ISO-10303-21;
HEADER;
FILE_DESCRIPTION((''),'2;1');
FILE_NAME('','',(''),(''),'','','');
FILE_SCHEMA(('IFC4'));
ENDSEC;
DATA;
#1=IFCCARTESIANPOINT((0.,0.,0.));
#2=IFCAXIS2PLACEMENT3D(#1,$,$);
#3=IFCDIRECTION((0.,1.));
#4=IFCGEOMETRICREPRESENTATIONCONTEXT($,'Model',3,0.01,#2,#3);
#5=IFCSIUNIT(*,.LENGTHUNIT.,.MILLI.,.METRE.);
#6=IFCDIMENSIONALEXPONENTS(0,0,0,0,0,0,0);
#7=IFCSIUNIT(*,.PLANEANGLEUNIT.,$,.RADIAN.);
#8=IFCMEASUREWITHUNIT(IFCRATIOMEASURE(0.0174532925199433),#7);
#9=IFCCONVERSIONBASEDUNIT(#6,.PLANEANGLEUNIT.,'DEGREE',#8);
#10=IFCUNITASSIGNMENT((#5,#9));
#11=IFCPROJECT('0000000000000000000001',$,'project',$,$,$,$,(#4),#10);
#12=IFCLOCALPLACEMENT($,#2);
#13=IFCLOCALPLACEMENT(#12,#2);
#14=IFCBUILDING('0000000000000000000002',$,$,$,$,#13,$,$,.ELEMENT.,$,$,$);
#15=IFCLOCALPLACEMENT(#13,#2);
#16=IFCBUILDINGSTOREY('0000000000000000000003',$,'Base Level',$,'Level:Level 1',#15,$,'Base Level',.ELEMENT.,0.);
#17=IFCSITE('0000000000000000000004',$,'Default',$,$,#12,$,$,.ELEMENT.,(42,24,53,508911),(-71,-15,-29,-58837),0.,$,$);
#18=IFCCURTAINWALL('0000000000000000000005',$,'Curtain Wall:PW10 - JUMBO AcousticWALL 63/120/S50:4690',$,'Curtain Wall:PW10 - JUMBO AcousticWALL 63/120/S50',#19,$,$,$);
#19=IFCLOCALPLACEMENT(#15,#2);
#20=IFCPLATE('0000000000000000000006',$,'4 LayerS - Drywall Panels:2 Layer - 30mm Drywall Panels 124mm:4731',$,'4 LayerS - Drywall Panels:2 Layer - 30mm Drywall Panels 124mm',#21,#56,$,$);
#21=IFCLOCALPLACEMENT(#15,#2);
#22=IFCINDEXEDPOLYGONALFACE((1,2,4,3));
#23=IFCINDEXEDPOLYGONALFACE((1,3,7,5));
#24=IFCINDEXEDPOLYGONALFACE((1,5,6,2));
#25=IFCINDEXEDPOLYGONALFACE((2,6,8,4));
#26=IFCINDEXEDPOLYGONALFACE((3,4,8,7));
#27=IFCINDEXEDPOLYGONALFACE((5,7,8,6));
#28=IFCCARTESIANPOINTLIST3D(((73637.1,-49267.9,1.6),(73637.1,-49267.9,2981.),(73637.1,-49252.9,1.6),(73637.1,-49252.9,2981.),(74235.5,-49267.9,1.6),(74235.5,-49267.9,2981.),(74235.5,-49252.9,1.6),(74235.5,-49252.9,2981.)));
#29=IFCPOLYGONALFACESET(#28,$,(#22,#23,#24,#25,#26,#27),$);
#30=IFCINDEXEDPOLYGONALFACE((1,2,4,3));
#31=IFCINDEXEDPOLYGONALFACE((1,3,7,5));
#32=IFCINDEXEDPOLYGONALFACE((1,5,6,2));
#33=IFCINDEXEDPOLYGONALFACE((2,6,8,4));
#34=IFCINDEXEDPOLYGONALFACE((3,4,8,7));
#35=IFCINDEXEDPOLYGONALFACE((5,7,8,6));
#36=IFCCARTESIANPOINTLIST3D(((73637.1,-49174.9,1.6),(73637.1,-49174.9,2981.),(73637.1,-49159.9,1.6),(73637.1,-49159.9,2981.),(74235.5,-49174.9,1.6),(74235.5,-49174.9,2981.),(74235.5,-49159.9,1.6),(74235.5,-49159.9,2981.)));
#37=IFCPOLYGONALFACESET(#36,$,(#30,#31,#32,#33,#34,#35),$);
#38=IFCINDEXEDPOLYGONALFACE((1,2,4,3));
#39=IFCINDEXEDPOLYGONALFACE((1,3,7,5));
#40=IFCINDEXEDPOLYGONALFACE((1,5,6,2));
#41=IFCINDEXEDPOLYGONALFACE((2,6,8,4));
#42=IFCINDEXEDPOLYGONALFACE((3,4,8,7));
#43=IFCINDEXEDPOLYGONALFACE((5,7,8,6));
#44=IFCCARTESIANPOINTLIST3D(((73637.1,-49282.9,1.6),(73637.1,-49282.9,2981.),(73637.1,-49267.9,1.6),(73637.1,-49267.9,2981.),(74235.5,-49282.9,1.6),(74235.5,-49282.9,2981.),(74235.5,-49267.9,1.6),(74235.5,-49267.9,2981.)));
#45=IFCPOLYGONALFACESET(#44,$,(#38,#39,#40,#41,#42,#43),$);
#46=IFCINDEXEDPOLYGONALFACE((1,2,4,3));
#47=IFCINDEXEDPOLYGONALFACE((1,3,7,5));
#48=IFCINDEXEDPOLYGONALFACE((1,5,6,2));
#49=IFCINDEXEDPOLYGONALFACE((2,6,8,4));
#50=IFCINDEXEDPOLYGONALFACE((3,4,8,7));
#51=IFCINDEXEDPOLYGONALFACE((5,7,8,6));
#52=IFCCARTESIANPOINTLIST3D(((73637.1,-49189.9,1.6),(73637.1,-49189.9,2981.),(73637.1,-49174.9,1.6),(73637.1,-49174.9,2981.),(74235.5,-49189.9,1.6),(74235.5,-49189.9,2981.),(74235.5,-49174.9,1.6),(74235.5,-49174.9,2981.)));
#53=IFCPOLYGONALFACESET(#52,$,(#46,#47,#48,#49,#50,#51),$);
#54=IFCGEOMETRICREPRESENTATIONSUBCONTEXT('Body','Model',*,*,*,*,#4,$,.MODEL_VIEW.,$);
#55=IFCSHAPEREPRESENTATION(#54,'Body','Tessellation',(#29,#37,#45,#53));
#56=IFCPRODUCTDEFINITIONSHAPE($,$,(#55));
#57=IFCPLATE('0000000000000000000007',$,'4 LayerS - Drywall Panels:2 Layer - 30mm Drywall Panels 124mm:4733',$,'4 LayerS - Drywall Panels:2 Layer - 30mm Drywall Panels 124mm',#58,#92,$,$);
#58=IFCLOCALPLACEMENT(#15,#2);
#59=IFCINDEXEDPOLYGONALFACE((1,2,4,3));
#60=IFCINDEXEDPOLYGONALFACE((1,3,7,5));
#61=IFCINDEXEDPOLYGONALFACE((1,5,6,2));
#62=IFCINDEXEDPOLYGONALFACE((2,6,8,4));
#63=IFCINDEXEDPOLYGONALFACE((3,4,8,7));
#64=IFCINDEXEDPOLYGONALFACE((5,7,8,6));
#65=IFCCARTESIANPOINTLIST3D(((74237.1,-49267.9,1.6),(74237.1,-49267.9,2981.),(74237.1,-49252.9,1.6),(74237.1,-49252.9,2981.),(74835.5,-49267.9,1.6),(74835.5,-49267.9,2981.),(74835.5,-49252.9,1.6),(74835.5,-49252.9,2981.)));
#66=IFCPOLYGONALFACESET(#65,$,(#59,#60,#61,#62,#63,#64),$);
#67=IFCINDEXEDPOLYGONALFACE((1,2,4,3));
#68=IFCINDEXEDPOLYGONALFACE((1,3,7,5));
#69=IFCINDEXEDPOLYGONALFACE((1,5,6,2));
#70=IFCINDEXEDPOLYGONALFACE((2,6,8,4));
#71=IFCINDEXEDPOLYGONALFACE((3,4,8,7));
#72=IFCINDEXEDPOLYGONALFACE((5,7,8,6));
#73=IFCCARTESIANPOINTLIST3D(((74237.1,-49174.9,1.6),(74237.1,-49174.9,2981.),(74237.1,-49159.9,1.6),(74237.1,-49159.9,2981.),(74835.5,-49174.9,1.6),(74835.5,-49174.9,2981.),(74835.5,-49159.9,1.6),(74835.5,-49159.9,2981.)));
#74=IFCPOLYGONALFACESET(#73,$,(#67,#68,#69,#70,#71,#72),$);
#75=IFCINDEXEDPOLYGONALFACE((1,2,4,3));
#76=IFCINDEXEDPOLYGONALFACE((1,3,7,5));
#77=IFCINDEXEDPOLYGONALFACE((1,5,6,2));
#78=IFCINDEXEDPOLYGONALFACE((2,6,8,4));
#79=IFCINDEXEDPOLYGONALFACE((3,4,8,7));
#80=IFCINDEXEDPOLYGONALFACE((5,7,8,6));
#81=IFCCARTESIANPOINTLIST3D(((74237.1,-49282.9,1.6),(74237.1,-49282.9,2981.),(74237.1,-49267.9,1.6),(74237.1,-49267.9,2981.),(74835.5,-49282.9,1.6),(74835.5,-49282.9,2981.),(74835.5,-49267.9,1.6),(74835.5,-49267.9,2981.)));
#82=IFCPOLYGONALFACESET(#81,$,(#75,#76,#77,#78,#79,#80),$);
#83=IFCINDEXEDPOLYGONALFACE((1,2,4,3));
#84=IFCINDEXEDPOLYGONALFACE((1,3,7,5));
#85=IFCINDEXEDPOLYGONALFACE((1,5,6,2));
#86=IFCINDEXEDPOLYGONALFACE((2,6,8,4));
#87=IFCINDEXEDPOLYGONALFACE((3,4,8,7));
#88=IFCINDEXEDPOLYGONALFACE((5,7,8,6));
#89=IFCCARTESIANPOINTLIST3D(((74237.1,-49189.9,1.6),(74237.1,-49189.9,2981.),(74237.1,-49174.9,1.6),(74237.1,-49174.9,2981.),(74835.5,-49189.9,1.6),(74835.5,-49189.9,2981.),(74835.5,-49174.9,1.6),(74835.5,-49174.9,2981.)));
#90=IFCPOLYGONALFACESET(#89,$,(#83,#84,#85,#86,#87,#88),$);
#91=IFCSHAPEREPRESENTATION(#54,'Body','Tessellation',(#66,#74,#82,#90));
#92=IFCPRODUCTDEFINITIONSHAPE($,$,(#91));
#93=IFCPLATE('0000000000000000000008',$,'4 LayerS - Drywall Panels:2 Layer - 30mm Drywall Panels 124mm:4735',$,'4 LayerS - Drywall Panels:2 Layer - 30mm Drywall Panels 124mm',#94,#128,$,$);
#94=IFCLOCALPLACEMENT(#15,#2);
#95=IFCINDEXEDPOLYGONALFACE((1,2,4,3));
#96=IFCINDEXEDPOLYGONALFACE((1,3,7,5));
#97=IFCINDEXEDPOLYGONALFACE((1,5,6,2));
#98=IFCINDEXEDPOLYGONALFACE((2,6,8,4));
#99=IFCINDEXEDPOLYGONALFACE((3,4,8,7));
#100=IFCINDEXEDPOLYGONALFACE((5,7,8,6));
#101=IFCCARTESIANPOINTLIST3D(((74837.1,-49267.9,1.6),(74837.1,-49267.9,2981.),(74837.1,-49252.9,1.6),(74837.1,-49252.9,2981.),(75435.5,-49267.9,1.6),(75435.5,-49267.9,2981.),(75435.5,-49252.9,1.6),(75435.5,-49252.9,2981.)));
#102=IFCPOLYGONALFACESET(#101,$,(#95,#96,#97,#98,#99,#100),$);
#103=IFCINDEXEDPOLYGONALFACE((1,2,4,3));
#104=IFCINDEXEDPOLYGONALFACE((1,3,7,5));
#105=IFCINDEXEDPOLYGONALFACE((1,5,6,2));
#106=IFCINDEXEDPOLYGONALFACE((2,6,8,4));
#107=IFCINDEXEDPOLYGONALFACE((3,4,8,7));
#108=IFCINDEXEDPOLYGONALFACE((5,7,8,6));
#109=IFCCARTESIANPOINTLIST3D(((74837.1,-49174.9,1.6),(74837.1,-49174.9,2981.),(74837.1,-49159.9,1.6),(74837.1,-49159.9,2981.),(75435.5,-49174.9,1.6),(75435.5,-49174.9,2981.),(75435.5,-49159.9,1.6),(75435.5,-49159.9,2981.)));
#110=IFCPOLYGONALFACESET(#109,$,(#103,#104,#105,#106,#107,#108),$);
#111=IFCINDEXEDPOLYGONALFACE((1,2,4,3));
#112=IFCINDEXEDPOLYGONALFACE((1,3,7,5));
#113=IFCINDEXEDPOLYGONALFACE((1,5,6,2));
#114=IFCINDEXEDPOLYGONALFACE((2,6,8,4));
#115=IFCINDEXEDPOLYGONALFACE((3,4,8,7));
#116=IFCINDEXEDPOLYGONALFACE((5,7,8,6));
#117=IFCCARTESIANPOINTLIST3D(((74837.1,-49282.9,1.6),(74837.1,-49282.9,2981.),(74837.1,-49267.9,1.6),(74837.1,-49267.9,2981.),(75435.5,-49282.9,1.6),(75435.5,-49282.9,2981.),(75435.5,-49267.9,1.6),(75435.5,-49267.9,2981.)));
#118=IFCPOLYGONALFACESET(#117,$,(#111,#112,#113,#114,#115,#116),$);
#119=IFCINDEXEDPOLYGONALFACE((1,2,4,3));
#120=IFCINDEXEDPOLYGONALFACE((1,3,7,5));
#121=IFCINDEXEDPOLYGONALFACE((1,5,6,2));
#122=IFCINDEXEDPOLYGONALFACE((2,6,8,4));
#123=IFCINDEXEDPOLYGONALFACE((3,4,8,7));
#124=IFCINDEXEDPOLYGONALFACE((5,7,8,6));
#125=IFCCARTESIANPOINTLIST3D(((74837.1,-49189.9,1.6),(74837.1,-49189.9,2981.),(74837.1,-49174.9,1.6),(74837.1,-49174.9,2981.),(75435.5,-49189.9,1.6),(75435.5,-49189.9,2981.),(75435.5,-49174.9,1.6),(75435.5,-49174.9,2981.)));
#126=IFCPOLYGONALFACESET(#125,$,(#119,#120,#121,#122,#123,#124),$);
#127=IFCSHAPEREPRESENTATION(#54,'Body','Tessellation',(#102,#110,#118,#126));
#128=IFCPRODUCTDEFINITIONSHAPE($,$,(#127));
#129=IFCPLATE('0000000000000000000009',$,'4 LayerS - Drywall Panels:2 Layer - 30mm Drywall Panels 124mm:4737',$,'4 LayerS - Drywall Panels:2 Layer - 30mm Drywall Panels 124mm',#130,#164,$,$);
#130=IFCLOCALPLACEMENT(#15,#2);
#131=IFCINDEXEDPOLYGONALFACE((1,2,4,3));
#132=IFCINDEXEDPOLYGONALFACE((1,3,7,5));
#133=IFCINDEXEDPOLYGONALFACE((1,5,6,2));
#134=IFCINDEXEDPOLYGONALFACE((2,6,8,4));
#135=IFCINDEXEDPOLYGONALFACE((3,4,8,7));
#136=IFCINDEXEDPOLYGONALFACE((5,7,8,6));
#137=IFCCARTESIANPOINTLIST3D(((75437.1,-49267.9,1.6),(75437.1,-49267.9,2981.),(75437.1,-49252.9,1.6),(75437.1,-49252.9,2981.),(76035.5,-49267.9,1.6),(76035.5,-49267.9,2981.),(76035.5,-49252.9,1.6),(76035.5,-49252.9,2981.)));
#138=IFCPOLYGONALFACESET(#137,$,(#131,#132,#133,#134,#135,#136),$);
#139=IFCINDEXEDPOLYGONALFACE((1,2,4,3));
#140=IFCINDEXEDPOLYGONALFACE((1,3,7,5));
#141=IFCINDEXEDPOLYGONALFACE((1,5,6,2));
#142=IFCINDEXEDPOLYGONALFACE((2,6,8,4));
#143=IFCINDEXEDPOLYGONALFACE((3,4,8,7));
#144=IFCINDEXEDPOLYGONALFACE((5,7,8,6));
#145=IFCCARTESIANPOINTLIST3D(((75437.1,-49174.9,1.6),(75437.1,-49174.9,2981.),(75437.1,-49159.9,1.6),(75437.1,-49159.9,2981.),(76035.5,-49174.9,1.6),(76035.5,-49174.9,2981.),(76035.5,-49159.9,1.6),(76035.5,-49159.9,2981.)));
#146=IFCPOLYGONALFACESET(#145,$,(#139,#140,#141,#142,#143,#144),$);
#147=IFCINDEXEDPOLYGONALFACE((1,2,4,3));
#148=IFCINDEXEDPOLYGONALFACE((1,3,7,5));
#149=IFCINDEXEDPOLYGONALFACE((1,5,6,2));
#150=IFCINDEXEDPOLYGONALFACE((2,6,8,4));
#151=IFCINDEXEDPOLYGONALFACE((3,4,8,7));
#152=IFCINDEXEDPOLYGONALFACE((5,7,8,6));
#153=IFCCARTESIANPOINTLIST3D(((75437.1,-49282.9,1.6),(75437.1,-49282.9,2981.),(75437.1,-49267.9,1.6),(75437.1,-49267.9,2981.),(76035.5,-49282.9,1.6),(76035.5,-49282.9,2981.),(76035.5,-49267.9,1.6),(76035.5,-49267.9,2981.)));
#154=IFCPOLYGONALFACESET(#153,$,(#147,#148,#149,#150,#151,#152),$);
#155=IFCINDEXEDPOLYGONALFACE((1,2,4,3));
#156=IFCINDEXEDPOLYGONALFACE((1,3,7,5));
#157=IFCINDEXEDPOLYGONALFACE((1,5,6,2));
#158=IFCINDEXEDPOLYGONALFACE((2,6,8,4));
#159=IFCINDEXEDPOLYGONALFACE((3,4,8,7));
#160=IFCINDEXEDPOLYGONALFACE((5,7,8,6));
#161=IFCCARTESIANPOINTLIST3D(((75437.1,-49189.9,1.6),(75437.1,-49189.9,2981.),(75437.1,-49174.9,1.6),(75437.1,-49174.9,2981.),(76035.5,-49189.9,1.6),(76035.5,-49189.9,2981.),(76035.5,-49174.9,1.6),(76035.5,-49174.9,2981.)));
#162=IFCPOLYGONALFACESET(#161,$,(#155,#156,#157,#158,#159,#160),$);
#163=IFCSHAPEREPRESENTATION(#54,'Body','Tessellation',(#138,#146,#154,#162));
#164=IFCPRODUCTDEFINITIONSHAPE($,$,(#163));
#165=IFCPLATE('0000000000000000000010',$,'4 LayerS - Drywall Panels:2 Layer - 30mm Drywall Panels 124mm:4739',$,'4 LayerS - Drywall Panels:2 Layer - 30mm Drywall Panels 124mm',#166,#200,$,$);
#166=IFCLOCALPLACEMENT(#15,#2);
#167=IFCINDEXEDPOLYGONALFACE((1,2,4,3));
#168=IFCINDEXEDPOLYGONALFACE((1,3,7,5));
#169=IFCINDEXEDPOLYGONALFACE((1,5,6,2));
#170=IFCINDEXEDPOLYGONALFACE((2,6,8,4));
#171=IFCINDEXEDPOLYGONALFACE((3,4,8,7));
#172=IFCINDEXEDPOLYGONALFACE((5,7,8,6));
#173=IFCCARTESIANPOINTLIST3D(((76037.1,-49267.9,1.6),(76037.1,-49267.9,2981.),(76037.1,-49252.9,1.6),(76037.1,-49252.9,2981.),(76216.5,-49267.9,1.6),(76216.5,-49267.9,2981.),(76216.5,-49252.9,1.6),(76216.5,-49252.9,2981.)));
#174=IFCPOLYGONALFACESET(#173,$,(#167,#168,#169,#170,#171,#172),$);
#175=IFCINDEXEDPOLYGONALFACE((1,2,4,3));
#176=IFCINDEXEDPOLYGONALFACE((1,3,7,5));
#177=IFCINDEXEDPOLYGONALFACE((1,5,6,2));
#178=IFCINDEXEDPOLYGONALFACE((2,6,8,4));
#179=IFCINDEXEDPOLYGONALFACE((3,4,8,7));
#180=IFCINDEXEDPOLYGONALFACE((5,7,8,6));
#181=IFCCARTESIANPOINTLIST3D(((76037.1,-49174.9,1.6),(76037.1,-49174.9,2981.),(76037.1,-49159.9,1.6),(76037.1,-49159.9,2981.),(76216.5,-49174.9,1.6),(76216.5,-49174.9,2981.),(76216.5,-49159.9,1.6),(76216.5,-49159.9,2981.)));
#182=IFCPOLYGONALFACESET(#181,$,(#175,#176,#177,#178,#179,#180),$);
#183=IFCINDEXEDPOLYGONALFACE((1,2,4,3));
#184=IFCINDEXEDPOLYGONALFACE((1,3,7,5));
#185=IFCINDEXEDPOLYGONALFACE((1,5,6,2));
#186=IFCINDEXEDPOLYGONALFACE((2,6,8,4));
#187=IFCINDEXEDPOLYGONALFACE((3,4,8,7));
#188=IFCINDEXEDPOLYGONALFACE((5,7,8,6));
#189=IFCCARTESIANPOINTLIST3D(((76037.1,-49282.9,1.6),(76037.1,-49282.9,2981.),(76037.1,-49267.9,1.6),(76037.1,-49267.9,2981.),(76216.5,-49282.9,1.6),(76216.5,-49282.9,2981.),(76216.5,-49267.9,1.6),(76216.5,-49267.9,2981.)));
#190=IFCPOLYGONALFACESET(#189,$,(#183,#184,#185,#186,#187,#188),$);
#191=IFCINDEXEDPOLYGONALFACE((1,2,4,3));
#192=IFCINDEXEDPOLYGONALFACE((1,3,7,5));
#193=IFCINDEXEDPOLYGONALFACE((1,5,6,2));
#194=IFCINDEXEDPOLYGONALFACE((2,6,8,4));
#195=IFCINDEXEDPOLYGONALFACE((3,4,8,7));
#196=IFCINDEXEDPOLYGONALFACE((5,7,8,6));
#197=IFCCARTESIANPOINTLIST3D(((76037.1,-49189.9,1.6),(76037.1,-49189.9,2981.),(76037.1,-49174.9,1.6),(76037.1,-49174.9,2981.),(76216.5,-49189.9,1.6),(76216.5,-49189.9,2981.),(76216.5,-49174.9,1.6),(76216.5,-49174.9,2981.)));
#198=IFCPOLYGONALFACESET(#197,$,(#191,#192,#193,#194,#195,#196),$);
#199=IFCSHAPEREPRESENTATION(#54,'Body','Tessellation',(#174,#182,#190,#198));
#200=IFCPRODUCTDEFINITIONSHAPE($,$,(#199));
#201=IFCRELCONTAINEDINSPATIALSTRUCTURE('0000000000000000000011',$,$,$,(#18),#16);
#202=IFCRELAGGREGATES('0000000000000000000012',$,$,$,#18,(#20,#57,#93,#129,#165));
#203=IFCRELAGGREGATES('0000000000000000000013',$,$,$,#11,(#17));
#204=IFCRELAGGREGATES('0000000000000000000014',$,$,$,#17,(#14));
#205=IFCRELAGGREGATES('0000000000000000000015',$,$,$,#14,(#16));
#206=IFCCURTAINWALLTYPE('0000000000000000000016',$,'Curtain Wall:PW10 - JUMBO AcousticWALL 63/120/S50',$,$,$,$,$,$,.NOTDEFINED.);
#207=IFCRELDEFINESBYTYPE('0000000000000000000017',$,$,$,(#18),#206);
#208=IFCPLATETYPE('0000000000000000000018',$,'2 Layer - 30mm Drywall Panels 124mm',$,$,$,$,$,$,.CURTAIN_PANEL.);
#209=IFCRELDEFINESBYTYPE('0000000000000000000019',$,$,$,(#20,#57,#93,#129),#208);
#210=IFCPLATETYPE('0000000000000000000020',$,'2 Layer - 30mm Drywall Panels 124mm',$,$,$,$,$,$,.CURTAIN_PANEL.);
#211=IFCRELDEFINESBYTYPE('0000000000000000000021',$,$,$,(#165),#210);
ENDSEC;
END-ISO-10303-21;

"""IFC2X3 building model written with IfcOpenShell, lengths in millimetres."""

from ifc_helpers import new_model, entity, si_unit, converted_unit, direction, frame, frame_2d, origin, origin_2d_with_axis, place, context, subcontext, project, spatial, rectangle, extrude, source, transform, mapped, type_object, type_shapes, element, aggregate, save


model = new_model("IFC2X3")

# Units and contexts
model_context = context("Model", 3, precision=0.01, world=origin(), true_north=direction((0.0, 1.0)))
body_context = subcontext(model_context, "Body", "Model", "MODEL_VIEW")
ifc_project = project(units=[si_unit("LENGTHUNIT", "METRE", prefix="MILLI"), converted_unit("PLANEANGLEUNIT", "DEGREE", entity("IfcRatioMeasure", 0.0174532925199433), si_unit("PLANEANGLEUNIT", "RADIAN"), dimensions=[0, 0, 0, 0, 0, 0, 0])], contexts=[model_context])

# Site, building, storey
site_placement = place(None, origin())
site = spatial("IfcSite", under=ifc_project, at=site_placement, Name="Default", CompositionType="ELEMENT", RefLatitude=(42, 24, 53, 508911), RefLongitude=(-71, -15, -29, -58837), RefElevation=0.0)
building_placement = place(site_placement, origin())
building = spatial("IfcBuilding", under=site, at=building_placement, CompositionType="ELEMENT")
storey_placement = place(building_placement, origin())
storey = spatial("IfcBuildingStorey", under=building, at=storey_placement, Name="Base Level", ObjectType="Level:Level 1", LongName="Base Level", CompositionType="ELEMENT", Elevation=0.0)

# Curtain wall, plates
curtain_wall_type = type_object("IfcCurtainWallType", Name="Curtain Wall:PW10 - JUMBO AcousticWALL 63/120/S50", PredefinedType="NOTDEFINED")
curtain_wall_placement = place(building_placement, origin())
curtain_wall = element("IfcCurtainWall", 1, at=curtain_wall_placement, inside=storey, type_object=curtain_wall_type, Name="Curtain Wall:PW10 - JUMBO AcousticWALL 63/120/S50:4690", ObjectType="Curtain Wall:PW10 - JUMBO AcousticWALL 63/120/S50")
plate_type_1 = type_object("IfcPlateType", Name="2 Layer - 30mm Drywall Panels 124mm", PredefinedType="CURTAIN_PANEL")
shared_shape_1 = source(origin(), body_context, "Body", "SweptSolid", [
    extrude(rectangle(XDim=15.0, YDim=598.4, at=origin_2d_with_axis()), frame((0.0, -39.0, 0.0), z_axis=(0.0, 0.0, 1.0), x_axis=(0.0, 1.0, 0.0)), (0.0, 0.0, 1.0), 2979.4),
    extrude(rectangle(XDim=15.0, YDim=598.4, at=origin_2d_with_axis()), frame((0.0, 54.0, 0.0), z_axis=(0.0, 0.0, 1.0), x_axis=(0.0, 1.0, 0.0)), (0.0, 0.0, 1.0), 2979.4),
    extrude(rectangle(XDim=598.4, YDim=15.0, at=frame_2d((0.0, 0.0), x_axis=(1.0, 0.0))), frame((0.0, -54.0, 0.0), z_axis=(0.0, 0.0, 1.0), x_axis=(-1.0, 0.0, 0.0)), (0.0, 0.0, 1.0), 2979.4),
    extrude(rectangle(XDim=15.0, YDim=598.4, at=frame_2d((0.0, 0.0), x_axis=(1.0, 0.0))), frame((0.0, 39.0, 0.0), z_axis=(0.0, 0.0, 1.0), x_axis=(0.0, 1.0, 0.0)), (0.0, 0.0, 1.0), 2979.4),
])
type_shapes(plate_type_1, [shared_shape_1])
plate_1_placement = place(curtain_wall_placement, frame((73936.3, -49221.4, 1.6)))
plate_1 = element("IfcPlate", 2, at=plate_1_placement, type_object=plate_type_1, Name="4 LayerS - Drywall Panels:2 Layer - 30mm Drywall Panels 124mm:4731", ObjectType="4 LayerS - Drywall Panels:2 Layer - 30mm Drywall Panels 124mm", context=body_context, shape_type="MappedRepresentation", body=[
    mapped(shared_shape_1, transform((0.0, 0.0, 0.0), scale=1.0)),
])
plate_2_placement = place(curtain_wall_placement, frame((74536.3, -49221.4, 1.6)))
plate_2 = element("IfcPlate", 3, at=plate_2_placement, type_object=plate_type_1, Name="4 LayerS - Drywall Panels:2 Layer - 30mm Drywall Panels 124mm:4733", ObjectType="4 LayerS - Drywall Panels:2 Layer - 30mm Drywall Panels 124mm", context=body_context, shape_type="MappedRepresentation", body=[
    mapped(shared_shape_1, transform((0.0, 0.0, 0.0), scale=1.0)),
])
plate_3_placement = place(curtain_wall_placement, frame((75136.3, -49221.4, 1.6)))
plate_3 = element("IfcPlate", 4, at=plate_3_placement, type_object=plate_type_1, Name="4 LayerS - Drywall Panels:2 Layer - 30mm Drywall Panels 124mm:4735", ObjectType="4 LayerS - Drywall Panels:2 Layer - 30mm Drywall Panels 124mm", context=body_context, shape_type="MappedRepresentation", body=[
    mapped(shared_shape_1, transform((0.0, 0.0, 0.0), scale=1.0)),
])
plate_4_placement = place(curtain_wall_placement, frame((75736.3, -49221.4, 1.6)))
plate_4 = element("IfcPlate", 5, at=plate_4_placement, type_object=plate_type_1, Name="4 LayerS - Drywall Panels:2 Layer - 30mm Drywall Panels 124mm:4737", ObjectType="4 LayerS - Drywall Panels:2 Layer - 30mm Drywall Panels 124mm", context=body_context, shape_type="MappedRepresentation", body=[
    mapped(shared_shape_1, transform((0.0, 0.0, 0.0), scale=1.0)),
])
plate_type_2 = type_object("IfcPlateType", Name="2 Layer - 30mm Drywall Panels 124mm", PredefinedType="CURTAIN_PANEL")
shared_shape_2 = source(origin(), body_context, "Body", "SweptSolid", [
    extrude(rectangle(XDim=15.0, YDim=179.4, at=origin_2d_with_axis()), frame((0.0, -39.0, 0.0), z_axis=(0.0, 0.0, 1.0), x_axis=(0.0, 1.0, 0.0)), (0.0, 0.0, 1.0), 2979.4),
    extrude(rectangle(XDim=15.0, YDim=179.4, at=origin_2d_with_axis()), frame((0.0, 54.0, 0.0), z_axis=(0.0, 0.0, 1.0), x_axis=(0.0, 1.0, 0.0)), (0.0, 0.0, 1.0), 2979.4),
    extrude(rectangle(XDim=179.4, YDim=15.0, at=frame_2d((0.0, 0.0), x_axis=(1.0, 0.0))), frame((0.0, -54.0, 0.0), z_axis=(0.0, 0.0, 1.0), x_axis=(-1.0, 0.0, 0.0)), (0.0, 0.0, 1.0), 2979.4),
    extrude(rectangle(XDim=15.0, YDim=179.4, at=frame_2d((0.0, 0.0), x_axis=(1.0, 0.0))), frame((0.0, 39.0, 0.0), z_axis=(0.0, 0.0, 1.0), x_axis=(0.0, 1.0, 0.0)), (0.0, 0.0, 1.0), 2979.4),
])
type_shapes(plate_type_2, [shared_shape_2])
plate_5_placement = place(curtain_wall_placement, frame((76126.8, -49221.4, 1.6)))
plate_5 = element("IfcPlate", 6, at=plate_5_placement, type_object=plate_type_2, Name="4 LayerS - Drywall Panels:2 Layer - 30mm Drywall Panels 124mm:4739", ObjectType="4 LayerS - Drywall Panels:2 Layer - 30mm Drywall Panels 124mm", context=body_context, shape_type="MappedRepresentation", body=[
    mapped(shared_shape_2, transform((0.0, 0.0, 0.0), scale=1.0)),
])
aggregate(curtain_wall, [plate_1, plate_2, plate_3, plate_4, plate_5])

save(model, "model.ifc")
